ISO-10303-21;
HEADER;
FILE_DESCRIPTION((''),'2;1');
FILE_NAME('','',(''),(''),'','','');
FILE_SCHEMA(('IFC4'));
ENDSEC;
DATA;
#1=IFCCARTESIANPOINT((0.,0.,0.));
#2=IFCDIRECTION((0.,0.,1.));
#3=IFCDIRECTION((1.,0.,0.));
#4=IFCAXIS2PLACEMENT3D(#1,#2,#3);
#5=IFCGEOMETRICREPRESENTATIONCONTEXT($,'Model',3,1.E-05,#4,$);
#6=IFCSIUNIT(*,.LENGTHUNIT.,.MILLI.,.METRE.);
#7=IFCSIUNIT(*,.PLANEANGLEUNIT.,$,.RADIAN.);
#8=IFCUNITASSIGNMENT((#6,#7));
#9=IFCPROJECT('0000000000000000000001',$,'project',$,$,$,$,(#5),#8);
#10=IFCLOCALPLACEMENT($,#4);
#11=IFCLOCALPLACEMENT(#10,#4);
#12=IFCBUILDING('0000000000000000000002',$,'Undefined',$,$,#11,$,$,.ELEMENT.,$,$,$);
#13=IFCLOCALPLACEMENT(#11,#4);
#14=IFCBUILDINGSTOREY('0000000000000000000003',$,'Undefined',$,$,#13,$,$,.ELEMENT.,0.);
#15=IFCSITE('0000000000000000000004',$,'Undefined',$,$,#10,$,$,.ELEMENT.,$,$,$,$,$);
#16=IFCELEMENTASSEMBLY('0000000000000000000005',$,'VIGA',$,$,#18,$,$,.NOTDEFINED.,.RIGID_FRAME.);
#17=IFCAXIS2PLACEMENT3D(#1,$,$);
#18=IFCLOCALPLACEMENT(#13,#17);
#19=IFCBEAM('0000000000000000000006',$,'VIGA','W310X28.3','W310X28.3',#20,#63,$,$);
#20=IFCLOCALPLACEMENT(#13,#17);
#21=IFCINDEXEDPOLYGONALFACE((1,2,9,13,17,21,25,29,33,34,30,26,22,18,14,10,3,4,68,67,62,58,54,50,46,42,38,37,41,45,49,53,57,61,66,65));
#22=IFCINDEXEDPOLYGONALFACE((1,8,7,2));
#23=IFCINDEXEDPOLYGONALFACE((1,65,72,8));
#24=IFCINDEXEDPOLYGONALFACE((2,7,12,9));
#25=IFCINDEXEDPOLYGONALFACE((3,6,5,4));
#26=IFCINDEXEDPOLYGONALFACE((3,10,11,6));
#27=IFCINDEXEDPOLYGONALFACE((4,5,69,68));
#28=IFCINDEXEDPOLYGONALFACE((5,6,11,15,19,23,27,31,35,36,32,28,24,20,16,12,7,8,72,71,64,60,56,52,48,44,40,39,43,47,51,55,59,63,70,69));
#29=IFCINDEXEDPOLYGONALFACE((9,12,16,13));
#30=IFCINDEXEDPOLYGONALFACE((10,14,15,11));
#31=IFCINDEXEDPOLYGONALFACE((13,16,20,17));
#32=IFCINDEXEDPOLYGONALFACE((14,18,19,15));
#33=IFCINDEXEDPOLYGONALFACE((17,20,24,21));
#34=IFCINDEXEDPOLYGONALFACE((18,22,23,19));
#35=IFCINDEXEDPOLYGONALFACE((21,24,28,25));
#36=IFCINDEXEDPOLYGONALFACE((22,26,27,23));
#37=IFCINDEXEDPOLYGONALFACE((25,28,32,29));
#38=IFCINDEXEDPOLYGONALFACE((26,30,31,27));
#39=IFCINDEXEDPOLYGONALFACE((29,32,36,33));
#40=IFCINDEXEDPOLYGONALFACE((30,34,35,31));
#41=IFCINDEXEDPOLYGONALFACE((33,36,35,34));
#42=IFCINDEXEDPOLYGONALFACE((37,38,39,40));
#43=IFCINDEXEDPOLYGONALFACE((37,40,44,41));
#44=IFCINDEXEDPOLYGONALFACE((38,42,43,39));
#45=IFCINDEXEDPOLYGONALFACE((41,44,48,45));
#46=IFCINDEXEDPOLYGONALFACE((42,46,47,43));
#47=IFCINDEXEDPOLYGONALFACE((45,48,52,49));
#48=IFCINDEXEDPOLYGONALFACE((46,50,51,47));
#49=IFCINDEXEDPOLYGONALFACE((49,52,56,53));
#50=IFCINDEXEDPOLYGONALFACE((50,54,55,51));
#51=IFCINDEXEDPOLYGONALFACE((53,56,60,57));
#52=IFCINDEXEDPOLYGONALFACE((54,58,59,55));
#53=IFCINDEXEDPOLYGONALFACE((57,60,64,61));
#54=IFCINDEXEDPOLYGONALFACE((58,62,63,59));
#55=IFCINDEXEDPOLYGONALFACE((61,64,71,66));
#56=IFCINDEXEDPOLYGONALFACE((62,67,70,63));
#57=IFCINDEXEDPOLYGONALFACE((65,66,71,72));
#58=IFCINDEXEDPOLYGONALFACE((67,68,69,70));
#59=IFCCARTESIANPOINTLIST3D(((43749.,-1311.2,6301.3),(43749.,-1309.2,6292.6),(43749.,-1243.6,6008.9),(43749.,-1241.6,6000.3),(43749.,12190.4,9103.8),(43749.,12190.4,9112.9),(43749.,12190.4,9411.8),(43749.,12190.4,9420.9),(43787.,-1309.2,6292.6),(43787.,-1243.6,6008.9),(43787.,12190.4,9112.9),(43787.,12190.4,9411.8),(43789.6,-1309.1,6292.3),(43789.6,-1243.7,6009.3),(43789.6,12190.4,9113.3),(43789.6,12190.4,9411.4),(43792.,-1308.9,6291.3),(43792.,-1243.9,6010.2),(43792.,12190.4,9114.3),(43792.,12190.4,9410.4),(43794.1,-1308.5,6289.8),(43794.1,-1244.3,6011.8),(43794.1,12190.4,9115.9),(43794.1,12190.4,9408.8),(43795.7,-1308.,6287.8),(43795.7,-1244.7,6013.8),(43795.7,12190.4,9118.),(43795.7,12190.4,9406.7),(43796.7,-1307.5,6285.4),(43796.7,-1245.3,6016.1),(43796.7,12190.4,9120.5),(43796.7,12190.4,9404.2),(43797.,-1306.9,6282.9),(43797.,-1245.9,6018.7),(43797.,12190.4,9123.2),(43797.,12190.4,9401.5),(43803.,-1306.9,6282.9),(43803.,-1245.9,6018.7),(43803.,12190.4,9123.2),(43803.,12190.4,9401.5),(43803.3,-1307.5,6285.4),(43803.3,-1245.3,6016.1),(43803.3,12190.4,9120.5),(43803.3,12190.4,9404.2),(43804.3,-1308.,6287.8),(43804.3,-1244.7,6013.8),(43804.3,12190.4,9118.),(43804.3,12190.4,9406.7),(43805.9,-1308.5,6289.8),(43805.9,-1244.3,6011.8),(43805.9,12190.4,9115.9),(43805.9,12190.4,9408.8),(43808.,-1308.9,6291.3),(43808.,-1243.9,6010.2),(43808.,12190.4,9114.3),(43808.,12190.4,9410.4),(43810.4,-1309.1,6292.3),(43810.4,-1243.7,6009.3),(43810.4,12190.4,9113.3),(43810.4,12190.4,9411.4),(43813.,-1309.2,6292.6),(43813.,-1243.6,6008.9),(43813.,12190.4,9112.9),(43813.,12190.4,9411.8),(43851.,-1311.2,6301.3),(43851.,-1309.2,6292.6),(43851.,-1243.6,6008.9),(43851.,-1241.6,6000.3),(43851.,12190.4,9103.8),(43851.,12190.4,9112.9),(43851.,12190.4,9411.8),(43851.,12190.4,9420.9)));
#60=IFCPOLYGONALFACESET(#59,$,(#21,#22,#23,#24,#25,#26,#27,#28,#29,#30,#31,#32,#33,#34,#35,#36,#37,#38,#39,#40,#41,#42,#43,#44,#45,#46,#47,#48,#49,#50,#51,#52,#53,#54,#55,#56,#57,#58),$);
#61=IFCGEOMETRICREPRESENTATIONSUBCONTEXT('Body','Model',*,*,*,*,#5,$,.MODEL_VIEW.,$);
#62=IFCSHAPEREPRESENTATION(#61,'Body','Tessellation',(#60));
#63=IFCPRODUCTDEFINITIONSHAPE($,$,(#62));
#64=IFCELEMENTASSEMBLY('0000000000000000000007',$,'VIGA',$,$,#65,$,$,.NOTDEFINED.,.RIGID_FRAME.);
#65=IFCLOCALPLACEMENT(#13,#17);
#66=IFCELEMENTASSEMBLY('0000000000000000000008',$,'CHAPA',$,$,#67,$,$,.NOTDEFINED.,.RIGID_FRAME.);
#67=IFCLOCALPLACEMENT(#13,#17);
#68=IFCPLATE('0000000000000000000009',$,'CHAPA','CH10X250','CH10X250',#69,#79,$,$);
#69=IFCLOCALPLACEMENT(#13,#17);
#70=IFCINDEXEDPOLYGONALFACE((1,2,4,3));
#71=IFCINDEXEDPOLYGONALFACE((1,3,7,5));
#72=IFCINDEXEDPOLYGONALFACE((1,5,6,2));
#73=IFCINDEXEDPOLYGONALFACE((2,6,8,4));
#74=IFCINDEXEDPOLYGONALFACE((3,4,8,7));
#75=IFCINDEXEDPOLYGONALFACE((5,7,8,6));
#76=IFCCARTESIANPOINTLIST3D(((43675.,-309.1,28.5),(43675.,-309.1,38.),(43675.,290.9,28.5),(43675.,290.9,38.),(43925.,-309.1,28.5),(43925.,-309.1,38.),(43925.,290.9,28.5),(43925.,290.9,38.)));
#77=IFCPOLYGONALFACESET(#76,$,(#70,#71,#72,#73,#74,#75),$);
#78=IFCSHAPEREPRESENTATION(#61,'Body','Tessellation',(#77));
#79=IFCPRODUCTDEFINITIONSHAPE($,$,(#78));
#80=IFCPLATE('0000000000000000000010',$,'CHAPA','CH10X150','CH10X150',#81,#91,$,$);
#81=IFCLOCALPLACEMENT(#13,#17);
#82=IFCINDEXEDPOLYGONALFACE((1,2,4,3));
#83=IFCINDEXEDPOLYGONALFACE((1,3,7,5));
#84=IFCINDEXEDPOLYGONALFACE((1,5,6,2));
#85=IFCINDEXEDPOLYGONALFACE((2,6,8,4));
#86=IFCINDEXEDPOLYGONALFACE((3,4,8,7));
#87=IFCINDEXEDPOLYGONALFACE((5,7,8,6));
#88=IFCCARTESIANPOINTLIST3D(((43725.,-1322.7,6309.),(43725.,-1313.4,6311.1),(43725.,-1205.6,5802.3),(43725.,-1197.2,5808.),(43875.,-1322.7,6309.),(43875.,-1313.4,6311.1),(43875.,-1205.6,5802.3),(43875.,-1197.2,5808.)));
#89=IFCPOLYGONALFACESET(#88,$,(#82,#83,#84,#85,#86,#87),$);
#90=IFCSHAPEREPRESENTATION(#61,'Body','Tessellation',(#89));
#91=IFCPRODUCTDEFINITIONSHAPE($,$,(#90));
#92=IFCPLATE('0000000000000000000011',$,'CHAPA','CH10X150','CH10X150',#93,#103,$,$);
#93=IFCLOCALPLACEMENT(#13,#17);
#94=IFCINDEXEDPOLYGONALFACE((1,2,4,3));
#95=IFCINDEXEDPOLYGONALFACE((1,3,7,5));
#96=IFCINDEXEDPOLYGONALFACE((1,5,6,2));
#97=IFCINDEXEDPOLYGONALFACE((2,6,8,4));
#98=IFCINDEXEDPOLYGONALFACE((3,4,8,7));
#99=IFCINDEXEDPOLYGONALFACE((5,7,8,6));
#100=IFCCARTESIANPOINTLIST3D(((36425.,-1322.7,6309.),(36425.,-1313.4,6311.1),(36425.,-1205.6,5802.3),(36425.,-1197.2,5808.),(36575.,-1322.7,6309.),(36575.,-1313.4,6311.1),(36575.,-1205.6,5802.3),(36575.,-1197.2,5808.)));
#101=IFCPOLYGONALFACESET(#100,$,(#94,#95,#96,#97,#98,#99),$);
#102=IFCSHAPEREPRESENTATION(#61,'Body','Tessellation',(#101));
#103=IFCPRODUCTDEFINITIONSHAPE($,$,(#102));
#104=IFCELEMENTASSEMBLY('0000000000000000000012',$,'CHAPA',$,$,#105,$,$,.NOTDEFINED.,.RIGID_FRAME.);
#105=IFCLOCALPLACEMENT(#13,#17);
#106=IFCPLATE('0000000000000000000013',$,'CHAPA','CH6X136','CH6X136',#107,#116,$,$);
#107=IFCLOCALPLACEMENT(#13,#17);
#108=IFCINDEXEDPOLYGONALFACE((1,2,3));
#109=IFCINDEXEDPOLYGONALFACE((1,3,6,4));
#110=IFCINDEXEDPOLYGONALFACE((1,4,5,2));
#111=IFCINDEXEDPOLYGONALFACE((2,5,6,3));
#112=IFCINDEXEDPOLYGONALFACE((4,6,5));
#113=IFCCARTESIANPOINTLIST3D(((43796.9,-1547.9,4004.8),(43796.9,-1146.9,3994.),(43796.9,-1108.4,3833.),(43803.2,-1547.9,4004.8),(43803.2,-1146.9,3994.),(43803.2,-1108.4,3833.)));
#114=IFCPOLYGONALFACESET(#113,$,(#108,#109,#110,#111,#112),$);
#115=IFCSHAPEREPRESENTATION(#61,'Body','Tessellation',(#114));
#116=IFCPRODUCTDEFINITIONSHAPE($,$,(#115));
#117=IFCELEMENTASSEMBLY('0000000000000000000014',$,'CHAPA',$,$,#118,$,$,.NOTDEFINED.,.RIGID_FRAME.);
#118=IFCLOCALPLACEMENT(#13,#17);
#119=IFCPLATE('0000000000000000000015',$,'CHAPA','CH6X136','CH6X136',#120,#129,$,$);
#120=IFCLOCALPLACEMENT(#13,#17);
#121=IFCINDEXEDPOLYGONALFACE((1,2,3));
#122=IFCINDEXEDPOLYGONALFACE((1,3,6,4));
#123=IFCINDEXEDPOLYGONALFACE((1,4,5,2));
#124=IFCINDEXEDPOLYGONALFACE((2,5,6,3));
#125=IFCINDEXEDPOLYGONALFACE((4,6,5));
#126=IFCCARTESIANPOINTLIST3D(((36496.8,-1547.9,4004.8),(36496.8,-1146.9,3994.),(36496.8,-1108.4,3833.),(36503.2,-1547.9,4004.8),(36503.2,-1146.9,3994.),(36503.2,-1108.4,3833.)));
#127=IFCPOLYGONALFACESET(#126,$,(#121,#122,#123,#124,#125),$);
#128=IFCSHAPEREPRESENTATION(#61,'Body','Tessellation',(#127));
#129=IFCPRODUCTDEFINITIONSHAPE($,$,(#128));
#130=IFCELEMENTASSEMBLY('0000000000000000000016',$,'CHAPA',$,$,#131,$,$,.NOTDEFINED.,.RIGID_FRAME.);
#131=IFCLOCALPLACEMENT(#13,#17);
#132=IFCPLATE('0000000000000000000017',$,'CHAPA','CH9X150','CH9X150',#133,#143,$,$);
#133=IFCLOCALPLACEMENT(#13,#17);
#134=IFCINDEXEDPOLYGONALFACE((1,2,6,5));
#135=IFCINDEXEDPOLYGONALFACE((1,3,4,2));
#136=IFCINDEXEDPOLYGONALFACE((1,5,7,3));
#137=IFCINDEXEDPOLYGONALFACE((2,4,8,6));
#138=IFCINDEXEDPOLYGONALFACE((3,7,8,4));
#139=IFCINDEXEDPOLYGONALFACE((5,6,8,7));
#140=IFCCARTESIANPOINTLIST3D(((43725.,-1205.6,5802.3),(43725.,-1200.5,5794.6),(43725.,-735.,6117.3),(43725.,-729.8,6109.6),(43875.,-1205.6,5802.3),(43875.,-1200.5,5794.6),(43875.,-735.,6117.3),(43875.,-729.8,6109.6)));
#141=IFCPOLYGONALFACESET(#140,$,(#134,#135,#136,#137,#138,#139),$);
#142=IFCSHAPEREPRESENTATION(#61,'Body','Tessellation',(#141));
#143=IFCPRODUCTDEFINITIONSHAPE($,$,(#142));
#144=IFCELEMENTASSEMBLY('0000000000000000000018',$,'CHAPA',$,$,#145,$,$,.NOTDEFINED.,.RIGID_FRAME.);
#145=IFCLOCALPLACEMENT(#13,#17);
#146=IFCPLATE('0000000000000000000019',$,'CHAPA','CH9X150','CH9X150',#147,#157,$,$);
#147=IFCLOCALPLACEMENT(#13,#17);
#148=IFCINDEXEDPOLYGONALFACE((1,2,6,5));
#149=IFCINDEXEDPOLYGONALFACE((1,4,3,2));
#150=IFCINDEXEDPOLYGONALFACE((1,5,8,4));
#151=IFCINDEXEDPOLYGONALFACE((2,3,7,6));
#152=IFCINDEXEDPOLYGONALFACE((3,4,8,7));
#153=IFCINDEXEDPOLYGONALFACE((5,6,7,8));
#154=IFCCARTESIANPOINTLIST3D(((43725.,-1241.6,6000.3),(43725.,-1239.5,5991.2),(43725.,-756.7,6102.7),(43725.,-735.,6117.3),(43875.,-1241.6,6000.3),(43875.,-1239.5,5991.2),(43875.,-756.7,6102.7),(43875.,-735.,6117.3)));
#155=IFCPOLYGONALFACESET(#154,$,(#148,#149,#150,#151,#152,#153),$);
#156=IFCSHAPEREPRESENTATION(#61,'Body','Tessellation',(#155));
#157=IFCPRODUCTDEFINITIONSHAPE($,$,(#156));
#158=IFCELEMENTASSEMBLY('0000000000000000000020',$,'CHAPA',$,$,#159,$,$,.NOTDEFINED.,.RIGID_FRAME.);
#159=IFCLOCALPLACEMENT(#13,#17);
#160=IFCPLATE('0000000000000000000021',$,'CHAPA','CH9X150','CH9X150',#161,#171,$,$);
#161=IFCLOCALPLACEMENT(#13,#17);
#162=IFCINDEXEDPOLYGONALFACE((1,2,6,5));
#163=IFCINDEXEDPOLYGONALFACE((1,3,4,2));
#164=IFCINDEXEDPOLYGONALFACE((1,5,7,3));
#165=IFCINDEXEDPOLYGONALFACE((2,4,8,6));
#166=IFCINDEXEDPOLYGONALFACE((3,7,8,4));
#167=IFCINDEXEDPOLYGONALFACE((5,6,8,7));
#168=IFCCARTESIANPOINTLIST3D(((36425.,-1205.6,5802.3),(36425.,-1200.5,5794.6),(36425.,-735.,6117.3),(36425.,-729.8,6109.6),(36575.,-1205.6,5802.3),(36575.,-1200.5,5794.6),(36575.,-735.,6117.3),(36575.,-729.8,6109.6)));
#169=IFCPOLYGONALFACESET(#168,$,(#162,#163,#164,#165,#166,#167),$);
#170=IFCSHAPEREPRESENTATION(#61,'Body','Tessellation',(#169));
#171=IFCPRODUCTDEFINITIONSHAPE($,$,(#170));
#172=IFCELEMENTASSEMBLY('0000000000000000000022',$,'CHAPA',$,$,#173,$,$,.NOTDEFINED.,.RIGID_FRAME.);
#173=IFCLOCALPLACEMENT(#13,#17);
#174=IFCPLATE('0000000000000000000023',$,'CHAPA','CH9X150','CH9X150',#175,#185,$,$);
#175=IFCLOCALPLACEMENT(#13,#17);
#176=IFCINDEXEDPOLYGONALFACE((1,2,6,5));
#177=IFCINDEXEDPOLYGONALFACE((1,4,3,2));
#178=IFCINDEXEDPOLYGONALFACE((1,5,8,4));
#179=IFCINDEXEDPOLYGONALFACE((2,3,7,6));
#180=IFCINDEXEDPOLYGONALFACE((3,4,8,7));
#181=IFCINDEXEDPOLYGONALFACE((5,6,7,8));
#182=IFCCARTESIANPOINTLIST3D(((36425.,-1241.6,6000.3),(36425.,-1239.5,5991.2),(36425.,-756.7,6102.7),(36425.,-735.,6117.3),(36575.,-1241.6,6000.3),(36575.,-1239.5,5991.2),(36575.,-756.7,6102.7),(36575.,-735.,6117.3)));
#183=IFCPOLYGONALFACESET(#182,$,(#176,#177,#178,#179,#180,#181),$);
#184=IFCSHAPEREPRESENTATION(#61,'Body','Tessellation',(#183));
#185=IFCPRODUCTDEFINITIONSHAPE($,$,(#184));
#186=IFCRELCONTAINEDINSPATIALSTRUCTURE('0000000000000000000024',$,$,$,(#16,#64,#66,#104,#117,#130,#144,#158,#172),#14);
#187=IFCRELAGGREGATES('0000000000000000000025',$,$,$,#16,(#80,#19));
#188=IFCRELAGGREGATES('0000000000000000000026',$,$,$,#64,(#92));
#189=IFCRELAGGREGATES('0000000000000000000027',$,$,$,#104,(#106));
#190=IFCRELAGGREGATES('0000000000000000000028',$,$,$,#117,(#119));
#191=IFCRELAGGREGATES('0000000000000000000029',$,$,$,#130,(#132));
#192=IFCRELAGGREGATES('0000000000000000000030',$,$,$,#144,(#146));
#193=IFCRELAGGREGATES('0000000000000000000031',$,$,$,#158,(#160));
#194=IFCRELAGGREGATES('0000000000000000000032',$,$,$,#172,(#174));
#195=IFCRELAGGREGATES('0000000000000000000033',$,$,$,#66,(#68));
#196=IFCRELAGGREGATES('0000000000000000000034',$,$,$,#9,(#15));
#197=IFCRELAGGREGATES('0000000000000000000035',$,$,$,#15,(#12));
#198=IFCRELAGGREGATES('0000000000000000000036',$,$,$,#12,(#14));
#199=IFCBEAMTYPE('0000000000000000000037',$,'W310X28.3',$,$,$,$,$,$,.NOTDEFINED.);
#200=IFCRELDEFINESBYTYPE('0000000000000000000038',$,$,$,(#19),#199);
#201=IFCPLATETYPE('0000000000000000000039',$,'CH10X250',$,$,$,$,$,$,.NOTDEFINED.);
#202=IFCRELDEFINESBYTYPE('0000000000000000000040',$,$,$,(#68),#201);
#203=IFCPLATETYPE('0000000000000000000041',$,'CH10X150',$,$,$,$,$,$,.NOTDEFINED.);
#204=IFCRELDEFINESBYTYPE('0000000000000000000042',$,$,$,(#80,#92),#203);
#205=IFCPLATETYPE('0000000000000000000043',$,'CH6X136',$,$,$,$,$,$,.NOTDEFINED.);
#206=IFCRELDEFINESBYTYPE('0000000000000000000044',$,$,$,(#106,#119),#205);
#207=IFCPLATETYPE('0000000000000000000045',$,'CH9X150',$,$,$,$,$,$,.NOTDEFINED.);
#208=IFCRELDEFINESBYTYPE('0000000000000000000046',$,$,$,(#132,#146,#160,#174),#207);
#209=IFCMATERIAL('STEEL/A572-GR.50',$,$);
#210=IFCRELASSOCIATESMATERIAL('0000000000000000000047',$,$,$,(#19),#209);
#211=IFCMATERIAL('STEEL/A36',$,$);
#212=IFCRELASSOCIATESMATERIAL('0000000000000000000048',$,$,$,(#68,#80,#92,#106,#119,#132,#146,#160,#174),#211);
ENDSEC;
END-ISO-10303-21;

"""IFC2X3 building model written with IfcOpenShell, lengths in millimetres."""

from ifc_helpers import new_model, si_unit, frame, origin_with_axes, origin_2d_with_axis, place, context, subcontext, project, spatial, polyline, i_section, outline, extrude, clip, halfspace, material, type_object, element, aggregate, save


model = new_model("IFC2X3")

# Units and contexts
model_context = context("Model", 3, precision=1e-05, world=origin_with_axes())
body_context = subcontext(model_context, "Body", "Model", "MODEL_VIEW")
ifc_project = project(units=[si_unit("LENGTHUNIT", "METRE", prefix="MILLI"), si_unit("PLANEANGLEUNIT", "RADIAN")], contexts=[model_context])

# Site, building, storey
site_placement = place(None, origin_with_axes())
site = spatial("IfcSite", under=ifc_project, at=site_placement, Name="Undefined", CompositionType="ELEMENT")
building_placement = place(site_placement, origin_with_axes())
building = spatial("IfcBuilding", under=site, at=building_placement, Name="Undefined", CompositionType="ELEMENT")
storey_placement = place(building_placement, origin_with_axes())
storey = spatial("IfcBuildingStorey", under=building, at=storey_placement, Name="Undefined", CompositionType="ELEMENT", Elevation=0.0)

# Element assemblies, beam
assembly_1_placement = place(storey_placement, origin_with_axes())
assembly_1 = element("IfcElementAssembly", 1, at=assembly_1_placement, inside=storey, Name="VIGA", AssemblyPlace="NOTDEFINED", PredefinedType="RIGID_FRAME")
ifc_material_1 = material(Name="STEEL/A572-GR.50")
beam_type_1 = type_object("IfcBeamType", Name="W310X28.3", PredefinedType="NOTDEFINED")
beam_1_placement = place(assembly_1_placement, frame((43800.0, -1276.4, 6150.8), z_axis=(0.0, 0.225124, -0.97433), x_axis=(0.0, 0.97433, 0.225124)))
beam_1 = element("IfcBeam", 2, at=beam_1_placement, type_object=beam_type_1, material=ifc_material_1, Name="VIGA", Description="W310X28.3", ObjectType="W310X28.3", context=body_context, shape_type="Clipping", body=[
    clip(extrude(i_section(OverallWidth=102.0, OverallDepth=309.0, WebThickness=6.0, FlangeThickness=8.9, FilletRadius=10.0, at=origin_2d_with_axis()), frame((13995.7, 0.0, 0.0), z_axis=(-1.0, 0.0, 0.0), x_axis=(0.0, -1.0, 0.0)), (0.0, 0.0, 1.0), 13995.7), halfspace(frame((13857.8, 0.0, -156.7), z_axis=(0.97433, 0.0, 0.225124), x_axis=(-0.225124, 0.0, 0.97433)), False)),
])
assembly_2_placement = place(storey_placement, origin_with_axes())
assembly_2 = element("IfcElementAssembly", 3, at=assembly_2_placement, inside=storey, Name="VIGA", AssemblyPlace="NOTDEFINED", PredefinedType="RIGID_FRAME")

# Element assembly, plate
assembly_3_placement = place(storey_placement, origin_with_axes())
assembly_3 = element("IfcElementAssembly", 4, at=assembly_3_placement, inside=storey, Name="CHAPA", AssemblyPlace="NOTDEFINED", PredefinedType="RIGID_FRAME")
ifc_material_2 = material(Name="STEEL/A36")
plate_type_1 = type_object("IfcPlateType", Name="CH10X250", PredefinedType="NOTDEFINED")
plate_1_placement = place(assembly_3_placement, frame((43675.0, -309.1, 33.2), z_axis=(0.0, 0.0, 1.0), x_axis=(1.0, 0.0, 0.0)))
plate_1 = element("IfcPlate", 5, at=plate_1_placement, type_object=plate_type_1, material=ifc_material_2, Name="CHAPA", Description="CH10X250", ObjectType="CH10X250", context=body_context, shape_type="SweptSolid", body=[
    extrude(outline(polyline([(0.0, 0.0), (250.0, 0.0), (250.0, 600.0), (0.0, 600.0), (0.0, 0.0)])), frame((0.0, 0.0, -4.8), z_axis=(0.0, 0.0, 1.0), x_axis=(1.0, 0.0, 0.0)), (0.0, 0.0, 1.0), 9.5),
])

# Plates
plate_type_2 = type_object("IfcPlateType", Name="CH10X150", PredefinedType="NOTDEFINED")
plate_2_placement = place(assembly_1_placement, frame((43875.0, -1318.1, 6310.1), z_axis=(0.0, 0.97433, 0.225124), x_axis=(0.0, 0.225124, -0.97433)))
plate_2 = element("IfcPlate", 6, at=plate_2_placement, type_object=plate_type_2, material=ifc_material_2, Name="CHAPA", Description="CH10X150", ObjectType="CH10X150", context=body_context, shape_type="Clipping", body=[
    clip(extrude(outline(polyline([(0.0, 0.0), (520.0, 0.0), (520.0, 150.0), (0.0, 150.0), (0.0, 0.0)])), frame((0.0, 0.0, -4.8), z_axis=(0.0, 0.0, 1.0), x_axis=(1.0, 0.0, 0.0)), (0.0, 0.0, 1.0), 9.5), halfspace(frame((516.4, -500.0, 4.8), z_axis=(0.934951, 0.0, 0.354778), x_axis=(0.0, 1.0, 0.0)), False)),
])
aggregate(assembly_1, [plate_2, beam_1])
plate_3_placement = place(assembly_2_placement, frame((36575.0, -1318.1, 6310.1), z_axis=(0.0, 0.97433, 0.225124), x_axis=(0.0, 0.225124, -0.97433)))
plate_3 = element("IfcPlate", 7, at=plate_3_placement, type_object=plate_type_2, material=ifc_material_2, Name="CHAPA", Description="CH10X150", ObjectType="CH10X150", context=body_context, shape_type="Clipping", body=[
    clip(extrude(outline(polyline([(0.0, 0.0), (520.0, 0.0), (520.0, 150.0), (0.0, 150.0), (0.0, 0.0)])), frame((0.0, 0.0, -4.8), z_axis=(0.0, 0.0, 1.0), x_axis=(1.0, 0.0, 0.0)), (0.0, 0.0, 1.0), 9.5), halfspace(frame((516.4, -500.0, 4.8), z_axis=(0.934951, 0.0, 0.354778), x_axis=(0.0, 1.0, 0.0)), False)),
])
aggregate(assembly_2, [plate_3])

# Element assemblies, plates
assembly_4_placement = place(storey_placement, origin_with_axes())
assembly_4 = element("IfcElementAssembly", 8, at=assembly_4_placement, inside=storey, Name="CHAPA", AssemblyPlace="NOTDEFINED", PredefinedType="RIGID_FRAME")
plate_type_3 = type_object("IfcPlateType", Name="CH6X136", PredefinedType="NOTDEFINED")
plate_4_placement = place(assembly_4_placement, frame((43800.0, -1146.9, 3994.0), z_axis=(1.0, 0.0, 0.0), x_axis=(0.0, -0.999636, 0.026972)))
plate_4 = element("IfcPlate", 9, at=plate_4_placement, type_object=plate_type_3, material=ifc_material_2, Name="CHAPA", Description="CH6X136", ObjectType="CH6X136", context=body_context, shape_type="SweptSolid", body=[
    extrude(outline(polyline([(0.0, 0.0), (401.1, 0.0), (-42.8, 159.9), (0.0, 0.0)])), frame((0.0, 0.0, -3.1), z_axis=(0.0, 0.0, 1.0), x_axis=(1.0, 0.0, 0.0)), (0.0, 0.0, 1.0), 6.3),
])
aggregate(assembly_4, [plate_4])
assembly_5_placement = place(storey_placement, origin_with_axes())
assembly_5 = element("IfcElementAssembly", 10, at=assembly_5_placement, inside=storey, Name="CHAPA", AssemblyPlace="NOTDEFINED", PredefinedType="RIGID_FRAME")
plate_5_placement = place(assembly_5_placement, frame((36500.0, -1146.9, 3994.0), z_axis=(1.0, 0.0, 0.0), x_axis=(0.0, -0.999636, 0.026972)))
plate_5 = element("IfcPlate", 11, at=plate_5_placement, type_object=plate_type_3, material=ifc_material_2, Name="CHAPA", Description="CH6X136", ObjectType="CH6X136", context=body_context, shape_type="SweptSolid", body=[
    extrude(outline(polyline([(0.0, 0.0), (401.1, 0.0), (-42.8, 159.9), (0.0, 0.0)])), frame((0.0, 0.0, -3.1), z_axis=(0.0, 0.0, 1.0), x_axis=(1.0, 0.0, 0.0)), (0.0, 0.0, 1.0), 6.3),
])
aggregate(assembly_5, [plate_5])
assembly_6_placement = place(storey_placement, origin_with_axes())
assembly_6 = element("IfcElementAssembly", 12, at=assembly_6_placement, inside=storey, Name="CHAPA", AssemblyPlace="NOTDEFINED", PredefinedType="RIGID_FRAME")
plate_type_4 = type_object("IfcPlateType", Name="CH9X150", PredefinedType="NOTDEFINED")
plate_6_placement = place(assembly_6_placement, frame((43875.0, -732.4, 6113.5), z_axis=(0.0, -0.55615, 0.831082), x_axis=(-1.0, 0.0, 0.0)))
plate_6 = element("IfcPlate", 13, at=plate_6_placement, type_object=plate_type_4, material=ifc_material_2, Name="CHAPA", Description="CH9X150", ObjectType="CH9X150", context=body_context, shape_type="SweptSolid", body=[
    extrude(outline(polyline([(0.0, 0.0), (150.0, 0.0), (150.0, 566.3), (0.0, 566.3), (0.0, 0.0)])), frame((0.0, 0.0, -4.7), z_axis=(0.0, 0.0, 1.0), x_axis=(1.0, 0.0, 0.0)), (0.0, 0.0, 1.0), 9.3),
])
aggregate(assembly_6, [plate_6])
assembly_7_placement = place(storey_placement, origin_with_axes())
assembly_7 = element("IfcElementAssembly", 14, at=assembly_7_placement, inside=storey, Name="CHAPA", AssemblyPlace="NOTDEFINED", PredefinedType="RIGID_FRAME")
plate_7_placement = place(assembly_7_placement, frame((43875.0, -1240.6, 5995.7), z_axis=(0.0, -0.225124, 0.97433), x_axis=(0.0, 0.97433, 0.225124)))
plate_7 = element("IfcPlate", 15, at=plate_7_placement, type_object=plate_type_4, material=ifc_material_2, Name="CHAPA", Description="CH9X150", ObjectType="CH9X150", context=body_context, shape_type="Clipping", body=[
    clip(extrude(outline(polyline([(0.0, 0.0), (520.0, 0.0), (520.0, 150.0), (0.0, 150.0), (0.0, 0.0)])), frame((0.0, 0.0, -4.7), z_axis=(0.0, 0.0, 1.0), x_axis=(1.0, 0.0, 0.0)), (0.0, 0.0, 1.0), 9.3), halfspace(frame((520.0, -500.0, 4.7), z_axis=(0.354778, 0.0, -0.934951), x_axis=(0.0, 1.0, 0.0)), False)),
])
aggregate(assembly_7, [plate_7])
assembly_8_placement = place(storey_placement, origin_with_axes())
assembly_8 = element("IfcElementAssembly", 16, at=assembly_8_placement, inside=storey, Name="CHAPA", AssemblyPlace="NOTDEFINED", PredefinedType="RIGID_FRAME")
plate_8_placement = place(assembly_8_placement, frame((36575.0, -732.4, 6113.5), z_axis=(0.0, -0.55615, 0.831082), x_axis=(-1.0, 0.0, 0.0)))
plate_8 = element("IfcPlate", 17, at=plate_8_placement, type_object=plate_type_4, material=ifc_material_2, Name="CHAPA", Description="CH9X150", ObjectType="CH9X150", context=body_context, shape_type="SweptSolid", body=[
    extrude(outline(polyline([(0.0, 0.0), (150.0, 0.0), (150.0, 566.3), (0.0, 566.3), (0.0, 0.0)])), frame((0.0, 0.0, -4.7), z_axis=(0.0, 0.0, 1.0), x_axis=(1.0, 0.0, 0.0)), (0.0, 0.0, 1.0), 9.3),
])
aggregate(assembly_8, [plate_8])
assembly_9_placement = place(storey_placement, origin_with_axes())
assembly_9 = element("IfcElementAssembly", 18, at=assembly_9_placement, inside=storey, Name="CHAPA", AssemblyPlace="NOTDEFINED", PredefinedType="RIGID_FRAME")
plate_9_placement = place(assembly_9_placement, frame((36575.0, -1240.6, 5995.7), z_axis=(0.0, -0.225124, 0.97433), x_axis=(0.0, 0.97433, 0.225124)))
plate_9 = element("IfcPlate", 19, at=plate_9_placement, type_object=plate_type_4, material=ifc_material_2, Name="CHAPA", Description="CH9X150", ObjectType="CH9X150", context=body_context, shape_type="Clipping", body=[
    clip(extrude(outline(polyline([(0.0, 0.0), (520.0, 0.0), (520.0, 150.0), (0.0, 150.0), (0.0, 0.0)])), frame((0.0, 0.0, -4.7), z_axis=(0.0, 0.0, 1.0), x_axis=(1.0, 0.0, 0.0)), (0.0, 0.0, 1.0), 9.3), halfspace(frame((520.0, -500.0, 4.7), z_axis=(0.354778, 0.0, -0.934951), x_axis=(0.0, 1.0, 0.0)), False)),
])
aggregate(assembly_9, [plate_9])

aggregate(assembly_3, [plate_1])

save(model, "model.ifc")
